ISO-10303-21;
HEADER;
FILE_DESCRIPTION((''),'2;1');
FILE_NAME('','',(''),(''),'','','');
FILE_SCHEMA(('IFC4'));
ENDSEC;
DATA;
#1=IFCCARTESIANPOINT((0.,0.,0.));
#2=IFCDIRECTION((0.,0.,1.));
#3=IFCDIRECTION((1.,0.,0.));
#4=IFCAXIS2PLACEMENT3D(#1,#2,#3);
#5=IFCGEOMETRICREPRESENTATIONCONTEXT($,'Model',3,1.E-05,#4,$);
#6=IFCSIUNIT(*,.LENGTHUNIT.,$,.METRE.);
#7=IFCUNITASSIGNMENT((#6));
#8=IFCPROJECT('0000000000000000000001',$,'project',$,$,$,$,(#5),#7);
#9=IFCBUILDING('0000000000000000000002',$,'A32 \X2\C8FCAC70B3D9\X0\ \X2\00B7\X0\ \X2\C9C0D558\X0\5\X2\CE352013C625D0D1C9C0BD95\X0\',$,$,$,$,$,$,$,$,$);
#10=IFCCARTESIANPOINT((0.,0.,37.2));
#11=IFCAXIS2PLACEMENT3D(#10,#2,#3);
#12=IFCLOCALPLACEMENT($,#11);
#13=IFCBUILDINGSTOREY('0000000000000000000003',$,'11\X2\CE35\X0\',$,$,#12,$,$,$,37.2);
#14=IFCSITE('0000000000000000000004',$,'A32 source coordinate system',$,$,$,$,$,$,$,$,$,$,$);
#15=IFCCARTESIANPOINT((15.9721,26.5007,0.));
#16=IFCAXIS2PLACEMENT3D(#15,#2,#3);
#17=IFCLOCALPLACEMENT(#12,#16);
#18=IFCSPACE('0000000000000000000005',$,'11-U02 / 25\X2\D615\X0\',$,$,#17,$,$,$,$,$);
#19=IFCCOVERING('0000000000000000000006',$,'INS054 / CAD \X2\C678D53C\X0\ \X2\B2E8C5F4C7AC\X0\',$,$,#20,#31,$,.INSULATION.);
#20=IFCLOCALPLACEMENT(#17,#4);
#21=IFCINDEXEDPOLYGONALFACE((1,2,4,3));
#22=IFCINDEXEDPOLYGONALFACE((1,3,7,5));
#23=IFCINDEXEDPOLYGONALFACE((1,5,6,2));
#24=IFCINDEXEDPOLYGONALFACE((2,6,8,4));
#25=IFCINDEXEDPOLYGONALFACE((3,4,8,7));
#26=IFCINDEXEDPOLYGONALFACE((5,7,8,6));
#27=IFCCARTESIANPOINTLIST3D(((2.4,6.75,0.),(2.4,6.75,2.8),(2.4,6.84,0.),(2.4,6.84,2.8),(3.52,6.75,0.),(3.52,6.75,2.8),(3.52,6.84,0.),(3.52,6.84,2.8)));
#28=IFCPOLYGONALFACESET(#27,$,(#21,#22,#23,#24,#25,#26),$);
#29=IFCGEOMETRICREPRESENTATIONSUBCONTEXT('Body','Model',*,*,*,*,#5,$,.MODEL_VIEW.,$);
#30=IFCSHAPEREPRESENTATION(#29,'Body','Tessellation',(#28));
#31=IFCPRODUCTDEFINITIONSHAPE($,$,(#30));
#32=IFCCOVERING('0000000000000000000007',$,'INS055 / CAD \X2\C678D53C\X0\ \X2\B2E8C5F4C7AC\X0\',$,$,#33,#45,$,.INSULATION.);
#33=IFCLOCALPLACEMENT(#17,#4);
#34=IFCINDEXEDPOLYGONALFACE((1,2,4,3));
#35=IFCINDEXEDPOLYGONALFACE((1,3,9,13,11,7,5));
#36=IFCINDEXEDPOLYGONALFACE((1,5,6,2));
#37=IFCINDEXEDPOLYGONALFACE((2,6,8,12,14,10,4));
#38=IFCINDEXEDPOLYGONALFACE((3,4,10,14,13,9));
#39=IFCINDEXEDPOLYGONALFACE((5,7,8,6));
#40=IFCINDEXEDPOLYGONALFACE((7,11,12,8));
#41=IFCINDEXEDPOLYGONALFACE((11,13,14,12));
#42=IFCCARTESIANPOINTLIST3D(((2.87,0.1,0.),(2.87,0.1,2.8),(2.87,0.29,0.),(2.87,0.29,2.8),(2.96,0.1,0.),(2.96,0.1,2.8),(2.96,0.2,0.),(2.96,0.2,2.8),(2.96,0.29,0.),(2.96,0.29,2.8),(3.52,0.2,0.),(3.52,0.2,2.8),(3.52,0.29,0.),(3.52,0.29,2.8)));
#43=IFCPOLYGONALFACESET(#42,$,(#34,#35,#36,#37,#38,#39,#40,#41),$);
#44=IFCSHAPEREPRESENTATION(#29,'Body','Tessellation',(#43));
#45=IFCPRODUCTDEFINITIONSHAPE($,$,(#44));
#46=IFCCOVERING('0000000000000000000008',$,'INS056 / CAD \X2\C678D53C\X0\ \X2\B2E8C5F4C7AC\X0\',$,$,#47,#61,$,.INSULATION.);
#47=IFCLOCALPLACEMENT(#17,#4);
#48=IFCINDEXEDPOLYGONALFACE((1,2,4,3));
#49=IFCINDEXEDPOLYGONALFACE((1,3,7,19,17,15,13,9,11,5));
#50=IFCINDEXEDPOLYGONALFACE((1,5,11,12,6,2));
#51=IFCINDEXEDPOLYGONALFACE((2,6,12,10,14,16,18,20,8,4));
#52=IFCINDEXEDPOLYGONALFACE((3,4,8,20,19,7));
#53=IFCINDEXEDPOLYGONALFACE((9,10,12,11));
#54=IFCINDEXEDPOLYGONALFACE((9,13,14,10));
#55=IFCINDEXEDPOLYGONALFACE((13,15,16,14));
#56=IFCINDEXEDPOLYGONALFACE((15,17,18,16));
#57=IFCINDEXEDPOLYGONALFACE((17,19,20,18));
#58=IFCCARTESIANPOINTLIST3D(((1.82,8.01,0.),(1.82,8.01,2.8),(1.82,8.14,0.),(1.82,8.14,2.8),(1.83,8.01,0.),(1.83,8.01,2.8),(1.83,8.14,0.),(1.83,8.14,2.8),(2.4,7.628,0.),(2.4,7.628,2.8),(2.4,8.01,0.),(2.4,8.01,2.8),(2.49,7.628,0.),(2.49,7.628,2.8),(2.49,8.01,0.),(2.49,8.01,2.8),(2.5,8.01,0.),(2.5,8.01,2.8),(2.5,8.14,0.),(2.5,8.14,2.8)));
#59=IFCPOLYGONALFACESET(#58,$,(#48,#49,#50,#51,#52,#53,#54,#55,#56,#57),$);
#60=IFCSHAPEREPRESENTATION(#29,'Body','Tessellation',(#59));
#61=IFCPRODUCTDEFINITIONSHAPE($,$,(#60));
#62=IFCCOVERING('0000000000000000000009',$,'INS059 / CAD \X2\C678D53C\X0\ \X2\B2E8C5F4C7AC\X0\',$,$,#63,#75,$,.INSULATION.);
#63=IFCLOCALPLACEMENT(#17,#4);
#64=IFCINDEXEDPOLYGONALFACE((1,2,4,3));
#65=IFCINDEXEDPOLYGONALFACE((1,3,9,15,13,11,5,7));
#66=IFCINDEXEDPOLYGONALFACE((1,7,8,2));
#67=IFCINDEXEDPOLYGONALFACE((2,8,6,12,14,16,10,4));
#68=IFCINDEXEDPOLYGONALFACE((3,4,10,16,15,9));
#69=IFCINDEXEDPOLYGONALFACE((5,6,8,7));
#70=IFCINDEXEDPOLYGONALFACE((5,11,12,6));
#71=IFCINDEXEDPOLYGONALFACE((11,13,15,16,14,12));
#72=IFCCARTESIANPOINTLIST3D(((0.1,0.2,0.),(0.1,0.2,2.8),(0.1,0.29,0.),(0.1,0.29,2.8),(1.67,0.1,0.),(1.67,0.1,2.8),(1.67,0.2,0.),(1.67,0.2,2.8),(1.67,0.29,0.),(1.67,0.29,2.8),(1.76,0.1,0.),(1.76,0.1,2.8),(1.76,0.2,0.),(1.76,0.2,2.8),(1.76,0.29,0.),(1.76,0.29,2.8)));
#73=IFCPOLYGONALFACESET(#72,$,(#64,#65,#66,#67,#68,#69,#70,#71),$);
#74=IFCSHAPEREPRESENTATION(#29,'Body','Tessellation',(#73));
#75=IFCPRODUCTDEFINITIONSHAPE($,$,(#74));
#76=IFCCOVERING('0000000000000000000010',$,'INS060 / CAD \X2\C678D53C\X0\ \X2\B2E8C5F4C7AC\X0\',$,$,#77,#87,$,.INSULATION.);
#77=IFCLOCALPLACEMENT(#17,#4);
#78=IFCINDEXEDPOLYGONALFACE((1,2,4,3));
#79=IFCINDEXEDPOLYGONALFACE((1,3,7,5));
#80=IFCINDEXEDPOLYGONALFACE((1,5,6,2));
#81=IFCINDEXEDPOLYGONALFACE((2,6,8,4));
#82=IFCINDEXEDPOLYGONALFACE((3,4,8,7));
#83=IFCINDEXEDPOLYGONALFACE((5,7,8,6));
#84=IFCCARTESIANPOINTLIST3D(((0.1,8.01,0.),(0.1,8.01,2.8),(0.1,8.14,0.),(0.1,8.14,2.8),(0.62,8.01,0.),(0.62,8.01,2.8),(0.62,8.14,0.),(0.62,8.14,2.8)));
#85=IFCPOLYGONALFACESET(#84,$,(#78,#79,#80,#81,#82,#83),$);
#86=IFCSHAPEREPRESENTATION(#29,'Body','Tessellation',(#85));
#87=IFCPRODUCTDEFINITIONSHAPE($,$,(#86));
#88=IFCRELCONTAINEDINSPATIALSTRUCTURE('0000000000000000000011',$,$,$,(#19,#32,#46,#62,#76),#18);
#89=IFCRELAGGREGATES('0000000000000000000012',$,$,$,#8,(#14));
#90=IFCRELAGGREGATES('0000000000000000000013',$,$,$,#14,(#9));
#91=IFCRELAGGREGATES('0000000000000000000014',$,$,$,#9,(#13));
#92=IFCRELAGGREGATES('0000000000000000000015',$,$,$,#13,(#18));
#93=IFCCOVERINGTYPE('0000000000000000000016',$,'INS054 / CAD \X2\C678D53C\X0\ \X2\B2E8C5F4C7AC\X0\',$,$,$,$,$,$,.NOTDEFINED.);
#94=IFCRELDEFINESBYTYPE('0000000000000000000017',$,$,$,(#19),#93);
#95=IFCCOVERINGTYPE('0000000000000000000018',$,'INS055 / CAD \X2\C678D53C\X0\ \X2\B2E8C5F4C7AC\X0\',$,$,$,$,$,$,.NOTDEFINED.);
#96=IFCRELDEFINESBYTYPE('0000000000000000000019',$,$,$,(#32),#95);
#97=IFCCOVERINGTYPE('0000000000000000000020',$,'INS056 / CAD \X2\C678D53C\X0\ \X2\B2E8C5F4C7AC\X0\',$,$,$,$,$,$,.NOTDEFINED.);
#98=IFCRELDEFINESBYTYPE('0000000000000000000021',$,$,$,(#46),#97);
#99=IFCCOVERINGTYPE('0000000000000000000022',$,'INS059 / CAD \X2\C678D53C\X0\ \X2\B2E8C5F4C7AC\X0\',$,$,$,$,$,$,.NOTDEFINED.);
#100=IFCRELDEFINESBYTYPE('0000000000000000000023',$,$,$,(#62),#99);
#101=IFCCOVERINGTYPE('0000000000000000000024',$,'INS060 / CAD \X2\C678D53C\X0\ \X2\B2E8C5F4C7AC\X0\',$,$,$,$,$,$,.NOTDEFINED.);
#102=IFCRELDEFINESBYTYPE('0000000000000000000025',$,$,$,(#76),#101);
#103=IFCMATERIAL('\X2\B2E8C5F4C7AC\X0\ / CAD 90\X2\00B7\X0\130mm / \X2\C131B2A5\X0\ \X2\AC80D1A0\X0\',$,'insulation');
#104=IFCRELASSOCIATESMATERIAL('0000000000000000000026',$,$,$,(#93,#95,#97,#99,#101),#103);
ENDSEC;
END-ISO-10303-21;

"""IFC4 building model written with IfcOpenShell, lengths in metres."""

from ifc_helpers import new_model, si_unit, frame, origin, origin_with_axes, place, context, subcontext, project, spatial, polyline, outline, extrude, source, transform, mapped, material, type_object, type_shapes, element, save


model = new_model("IFC4")

# Units and contexts
model_context = context("Model", 3, precision=1e-05, world=origin_with_axes())
body_context = subcontext(model_context, "Body", "Model", "MODEL_VIEW")
ifc_project = project(units=[si_unit("LENGTHUNIT", "METRE")], contexts=[model_context])

# Site, building, storey, space
storey_placement = place(None, frame((0.0, 0.0, 37.2), z_axis=(0.0, 0.0, 1.0), x_axis=(1.0, 0.0, 0.0)))
space_placement = place(storey_placement, frame((15.9721, 26.5007, 0.0), z_axis=(0.0, 0.0, 1.0), x_axis=(1.0, 0.0, 0.0)))
site = spatial("IfcSite", under=ifc_project, Name="A32 source coordinate system")
building = spatial("IfcBuilding", under=site, Name="A32 주거동 · 지하5층–옥탑지붕")
storey = spatial("IfcBuildingStorey", under=building, at=storey_placement, Name="11층", Elevation=37.2)
space = spatial("IfcSpace", under=storey, at=space_placement, Name="11-U02 / 25형")

# Coverings
ifc_material = material(Name="단열재 / CAD 90·130mm / 성능 검토", Category="insulation")
covering_type_1 = type_object("IfcCoveringType", Name="INS054 / CAD 외피 단열재", PredefinedType="NOTDEFINED", material=ifc_material)
shared_shape_1 = source(origin(), body_context, "Body", "SweptSolid", [
    extrude(outline(polyline([(2.4, 6.84), (3.52, 6.84), (3.52, 6.75), (2.4, 6.75), (2.4, 6.84)])), origin(), (0.0, 0.0, 1.0), 2.8),
])
type_shapes(covering_type_1, [shared_shape_1])
covering_1_placement = place(space_placement, origin_with_axes())
element("IfcCovering", 1, at=covering_1_placement, inside=space, type_object=covering_type_1, Name="INS054 / CAD 외피 단열재", PredefinedType="INSULATION", context=body_context, shape_type="MappedRepresentation", body=[
    mapped(shared_shape_1, transform((0.0, 0.0, 0.0), scale=1.0)),
])
covering_type_2 = type_object("IfcCoveringType", Name="INS055 / CAD 외피 단열재", PredefinedType="NOTDEFINED", material=ifc_material)
shared_shape_2 = source(origin(), body_context, "Body", "SweptSolid", [
    extrude(outline(polyline([(2.87, 0.29), (2.96, 0.29), (3.52, 0.29), (3.52, 0.2), (2.96, 0.2), (2.96, 0.1), (2.87, 0.1), (2.87, 0.29)])), origin(), (0.0, 0.0, 1.0), 2.8),
])
type_shapes(covering_type_2, [shared_shape_2])
covering_2_placement = place(space_placement, origin_with_axes())
element("IfcCovering", 2, at=covering_2_placement, inside=space, type_object=covering_type_2, Name="INS055 / CAD 외피 단열재", PredefinedType="INSULATION", context=body_context, shape_type="MappedRepresentation", body=[
    mapped(shared_shape_2, transform((0.0, 0.0, 0.0), scale=1.0)),
])
covering_type_3 = type_object("IfcCoveringType", Name="INS056 / CAD 외피 단열재", PredefinedType="NOTDEFINED", material=ifc_material)
shared_shape_3 = source(origin(), body_context, "Body", "SweptSolid", [
    extrude(outline(polyline([(2.49, 7.628), (2.4, 7.628), (2.4, 8.01), (1.83, 8.01), (1.82, 8.01), (1.82, 8.14), (1.83, 8.14), (2.5, 8.14), (2.5, 8.01), (2.49, 8.01), (2.49, 7.628)])), origin(), (0.0, 0.0, 1.0), 2.8),
])
type_shapes(covering_type_3, [shared_shape_3])
covering_3_placement = place(space_placement, origin_with_axes())
element("IfcCovering", 3, at=covering_3_placement, inside=space, type_object=covering_type_3, Name="INS056 / CAD 외피 단열재", PredefinedType="INSULATION", context=body_context, shape_type="MappedRepresentation", body=[
    mapped(shared_shape_3, transform((0.0, 0.0, 0.0), scale=1.0)),
])
covering_type_4 = type_object("IfcCoveringType", Name="INS059 / CAD 외피 단열재", PredefinedType="NOTDEFINED", material=ifc_material)
shared_shape_4 = source(origin(), body_context, "Body", "SweptSolid", [
    extrude(outline(polyline([(1.76, 0.1), (1.67, 0.1), (1.67, 0.2), (0.1, 0.2), (0.1, 0.29), (1.67, 0.29), (1.76, 0.29), (1.76, 0.2), (1.76, 0.1)])), origin(), (0.0, 0.0, 1.0), 2.8),
])
type_shapes(covering_type_4, [shared_shape_4])
covering_4_placement = place(space_placement, origin_with_axes())
element("IfcCovering", 4, at=covering_4_placement, inside=space, type_object=covering_type_4, Name="INS059 / CAD 외피 단열재", PredefinedType="INSULATION", context=body_context, shape_type="MappedRepresentation", body=[
    mapped(shared_shape_4, transform((0.0, 0.0, 0.0), scale=1.0)),
])
covering_type_5 = type_object("IfcCoveringType", Name="INS060 / CAD 외피 단열재", PredefinedType="NOTDEFINED", material=ifc_material)
shared_shape_5 = source(origin(), body_context, "Body", "SweptSolid", [
    extrude(outline(polyline([(0.1, 8.01), (0.1, 8.14), (0.62, 8.14), (0.62, 8.01), (0.1, 8.01)])), origin(), (0.0, 0.0, 1.0), 2.8),
])
type_shapes(covering_type_5, [shared_shape_5])
covering_5_placement = place(space_placement, origin_with_axes())
element("IfcCovering", 5, at=covering_5_placement, inside=space, type_object=covering_type_5, Name="INS060 / CAD 외피 단열재", PredefinedType="INSULATION", context=body_context, shape_type="MappedRepresentation", body=[
    mapped(shared_shape_5, transform((0.0, 0.0, 0.0), scale=1.0)),
])

save(model, "model.ifc")
